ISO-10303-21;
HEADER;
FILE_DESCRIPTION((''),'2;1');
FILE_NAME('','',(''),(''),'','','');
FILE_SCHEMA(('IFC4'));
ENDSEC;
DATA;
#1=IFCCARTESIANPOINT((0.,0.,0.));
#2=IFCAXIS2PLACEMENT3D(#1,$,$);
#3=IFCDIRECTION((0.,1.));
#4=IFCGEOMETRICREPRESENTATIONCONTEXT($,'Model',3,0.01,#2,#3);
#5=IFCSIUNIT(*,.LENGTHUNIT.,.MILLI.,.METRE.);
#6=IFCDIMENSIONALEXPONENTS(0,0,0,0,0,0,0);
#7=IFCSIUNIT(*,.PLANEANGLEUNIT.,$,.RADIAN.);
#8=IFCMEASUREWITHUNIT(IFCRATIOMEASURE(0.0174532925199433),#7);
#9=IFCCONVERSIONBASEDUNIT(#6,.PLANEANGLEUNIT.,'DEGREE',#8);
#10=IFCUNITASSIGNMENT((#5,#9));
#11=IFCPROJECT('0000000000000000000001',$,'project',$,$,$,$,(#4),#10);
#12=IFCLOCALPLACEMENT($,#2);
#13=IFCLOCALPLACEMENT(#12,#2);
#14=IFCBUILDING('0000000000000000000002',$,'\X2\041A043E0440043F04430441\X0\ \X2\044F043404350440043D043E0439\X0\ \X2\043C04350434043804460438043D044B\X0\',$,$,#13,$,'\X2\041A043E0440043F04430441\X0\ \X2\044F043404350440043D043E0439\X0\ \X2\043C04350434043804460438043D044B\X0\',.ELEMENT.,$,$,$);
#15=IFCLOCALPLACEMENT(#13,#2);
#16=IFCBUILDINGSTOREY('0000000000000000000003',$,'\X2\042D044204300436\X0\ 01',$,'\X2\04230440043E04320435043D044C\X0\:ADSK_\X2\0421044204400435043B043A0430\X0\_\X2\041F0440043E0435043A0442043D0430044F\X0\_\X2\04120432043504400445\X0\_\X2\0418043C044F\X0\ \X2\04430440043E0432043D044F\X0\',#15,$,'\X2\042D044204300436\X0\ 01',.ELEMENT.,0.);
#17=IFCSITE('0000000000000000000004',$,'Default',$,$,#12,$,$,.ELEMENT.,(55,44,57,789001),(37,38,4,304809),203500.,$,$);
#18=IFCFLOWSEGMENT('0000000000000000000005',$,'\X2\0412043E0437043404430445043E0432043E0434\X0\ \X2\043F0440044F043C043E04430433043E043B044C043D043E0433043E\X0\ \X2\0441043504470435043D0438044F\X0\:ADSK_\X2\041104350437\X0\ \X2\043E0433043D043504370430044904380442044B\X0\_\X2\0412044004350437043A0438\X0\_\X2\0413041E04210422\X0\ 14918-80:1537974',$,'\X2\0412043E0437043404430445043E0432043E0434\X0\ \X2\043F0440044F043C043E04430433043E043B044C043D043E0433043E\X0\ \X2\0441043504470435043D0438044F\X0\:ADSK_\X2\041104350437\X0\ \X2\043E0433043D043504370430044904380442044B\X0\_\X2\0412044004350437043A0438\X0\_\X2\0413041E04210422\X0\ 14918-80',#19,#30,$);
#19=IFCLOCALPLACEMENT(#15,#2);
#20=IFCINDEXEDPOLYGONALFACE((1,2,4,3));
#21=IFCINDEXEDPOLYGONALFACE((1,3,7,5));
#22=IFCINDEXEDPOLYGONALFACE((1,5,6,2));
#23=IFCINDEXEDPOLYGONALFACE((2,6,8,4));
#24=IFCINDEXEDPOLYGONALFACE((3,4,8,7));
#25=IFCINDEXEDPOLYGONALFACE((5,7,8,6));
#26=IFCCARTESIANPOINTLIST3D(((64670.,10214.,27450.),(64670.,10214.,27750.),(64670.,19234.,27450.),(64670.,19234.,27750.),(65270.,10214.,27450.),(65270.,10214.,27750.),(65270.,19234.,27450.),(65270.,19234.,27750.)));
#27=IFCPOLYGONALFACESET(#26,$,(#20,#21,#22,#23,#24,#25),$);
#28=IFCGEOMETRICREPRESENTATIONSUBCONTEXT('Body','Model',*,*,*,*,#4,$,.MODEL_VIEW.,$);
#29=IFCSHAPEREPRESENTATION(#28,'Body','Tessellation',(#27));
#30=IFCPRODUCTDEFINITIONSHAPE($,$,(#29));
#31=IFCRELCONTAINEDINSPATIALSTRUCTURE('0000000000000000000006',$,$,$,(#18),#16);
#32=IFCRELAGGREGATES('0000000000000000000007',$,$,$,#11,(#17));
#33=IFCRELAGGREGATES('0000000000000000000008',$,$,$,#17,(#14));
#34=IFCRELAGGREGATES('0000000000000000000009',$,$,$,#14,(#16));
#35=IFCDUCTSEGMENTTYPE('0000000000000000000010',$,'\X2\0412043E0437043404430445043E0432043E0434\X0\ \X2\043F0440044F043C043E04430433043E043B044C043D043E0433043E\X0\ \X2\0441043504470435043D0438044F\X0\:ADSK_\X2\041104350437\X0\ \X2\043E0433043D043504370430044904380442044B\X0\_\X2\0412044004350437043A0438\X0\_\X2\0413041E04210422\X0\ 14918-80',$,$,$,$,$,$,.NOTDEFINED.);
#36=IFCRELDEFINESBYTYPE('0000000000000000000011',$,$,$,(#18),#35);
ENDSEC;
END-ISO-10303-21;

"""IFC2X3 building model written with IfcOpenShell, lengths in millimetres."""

from ifc_helpers import new_model, entity, si_unit, converted_unit, direction, frame, origin, origin_2d_with_axis, place, context, subcontext, project, spatial, rectangle, extrude, type_object, element, save


model = new_model("IFC2X3")

# Units and contexts
model_context = context("Model", 3, precision=0.01, world=origin(), true_north=direction((0.0, 1.0)))
body_context = subcontext(model_context, "Body", "Model", "MODEL_VIEW")
ifc_project = project(units=[si_unit("LENGTHUNIT", "METRE", prefix="MILLI"), converted_unit("PLANEANGLEUNIT", "DEGREE", entity("IfcRatioMeasure", 0.0174532925199433), si_unit("PLANEANGLEUNIT", "RADIAN"), dimensions=[0, 0, 0, 0, 0, 0, 0])], contexts=[model_context])

# Site, building, storey
site_placement = place(None, origin())
site = spatial("IfcSite", under=ifc_project, at=site_placement, Name="Default", CompositionType="ELEMENT", RefLatitude=(55, 44, 57, 789001), RefLongitude=(37, 38, 4, 304809), RefElevation=203500.0)
building_placement = place(site_placement, origin())
building = spatial("IfcBuilding", under=site, at=building_placement, Name="Корпус ядерной медицины", LongName="Корпус ядерной медицины", CompositionType="ELEMENT")
storey_placement = place(building_placement, origin())
storey = spatial("IfcBuildingStorey", under=building, at=storey_placement, Name="Этаж 01", ObjectType="Уровень:ADSK_Стрелка_Проектная_Вверх_Имя уровня", LongName="Этаж 01", CompositionType="ELEMENT", Elevation=0.0)

# Flow segment
duct_segment_type_1 = type_object("IfcDuctSegmentType", Name="Воздуховод прямоугольного сечения:ADSK_Без огнезащиты_Врезки_ГОСТ 14918-80", PredefinedType="NOTDEFINED")
flow_segment_1_placement = place(storey_placement, frame((64670.0, 10214.0, 27450.0)))
element("IfcFlowSegment", 1, at=flow_segment_1_placement, inside=storey, type_object=duct_segment_type_1, Name="Воздуховод прямоугольного сечения:ADSK_Без огнезащиты_Врезки_ГОСТ 14918-80:1537974", ObjectType="Воздуховод прямоугольного сечения:ADSK_Без огнезащиты_Врезки_ГОСТ 14918-80", context=body_context, shape_type="SweptSolid", body=[
    extrude(rectangle(XDim=9020.0, YDim=600.0, at=origin_2d_with_axis()), frame((300.0, 4510.0, 0.0), z_axis=(0.0, 0.0, 1.0), x_axis=(0.0, 1.0, 0.0)), (0.0, 0.0, 1.0), 300.0),
])

save(model, "model.ifc")
